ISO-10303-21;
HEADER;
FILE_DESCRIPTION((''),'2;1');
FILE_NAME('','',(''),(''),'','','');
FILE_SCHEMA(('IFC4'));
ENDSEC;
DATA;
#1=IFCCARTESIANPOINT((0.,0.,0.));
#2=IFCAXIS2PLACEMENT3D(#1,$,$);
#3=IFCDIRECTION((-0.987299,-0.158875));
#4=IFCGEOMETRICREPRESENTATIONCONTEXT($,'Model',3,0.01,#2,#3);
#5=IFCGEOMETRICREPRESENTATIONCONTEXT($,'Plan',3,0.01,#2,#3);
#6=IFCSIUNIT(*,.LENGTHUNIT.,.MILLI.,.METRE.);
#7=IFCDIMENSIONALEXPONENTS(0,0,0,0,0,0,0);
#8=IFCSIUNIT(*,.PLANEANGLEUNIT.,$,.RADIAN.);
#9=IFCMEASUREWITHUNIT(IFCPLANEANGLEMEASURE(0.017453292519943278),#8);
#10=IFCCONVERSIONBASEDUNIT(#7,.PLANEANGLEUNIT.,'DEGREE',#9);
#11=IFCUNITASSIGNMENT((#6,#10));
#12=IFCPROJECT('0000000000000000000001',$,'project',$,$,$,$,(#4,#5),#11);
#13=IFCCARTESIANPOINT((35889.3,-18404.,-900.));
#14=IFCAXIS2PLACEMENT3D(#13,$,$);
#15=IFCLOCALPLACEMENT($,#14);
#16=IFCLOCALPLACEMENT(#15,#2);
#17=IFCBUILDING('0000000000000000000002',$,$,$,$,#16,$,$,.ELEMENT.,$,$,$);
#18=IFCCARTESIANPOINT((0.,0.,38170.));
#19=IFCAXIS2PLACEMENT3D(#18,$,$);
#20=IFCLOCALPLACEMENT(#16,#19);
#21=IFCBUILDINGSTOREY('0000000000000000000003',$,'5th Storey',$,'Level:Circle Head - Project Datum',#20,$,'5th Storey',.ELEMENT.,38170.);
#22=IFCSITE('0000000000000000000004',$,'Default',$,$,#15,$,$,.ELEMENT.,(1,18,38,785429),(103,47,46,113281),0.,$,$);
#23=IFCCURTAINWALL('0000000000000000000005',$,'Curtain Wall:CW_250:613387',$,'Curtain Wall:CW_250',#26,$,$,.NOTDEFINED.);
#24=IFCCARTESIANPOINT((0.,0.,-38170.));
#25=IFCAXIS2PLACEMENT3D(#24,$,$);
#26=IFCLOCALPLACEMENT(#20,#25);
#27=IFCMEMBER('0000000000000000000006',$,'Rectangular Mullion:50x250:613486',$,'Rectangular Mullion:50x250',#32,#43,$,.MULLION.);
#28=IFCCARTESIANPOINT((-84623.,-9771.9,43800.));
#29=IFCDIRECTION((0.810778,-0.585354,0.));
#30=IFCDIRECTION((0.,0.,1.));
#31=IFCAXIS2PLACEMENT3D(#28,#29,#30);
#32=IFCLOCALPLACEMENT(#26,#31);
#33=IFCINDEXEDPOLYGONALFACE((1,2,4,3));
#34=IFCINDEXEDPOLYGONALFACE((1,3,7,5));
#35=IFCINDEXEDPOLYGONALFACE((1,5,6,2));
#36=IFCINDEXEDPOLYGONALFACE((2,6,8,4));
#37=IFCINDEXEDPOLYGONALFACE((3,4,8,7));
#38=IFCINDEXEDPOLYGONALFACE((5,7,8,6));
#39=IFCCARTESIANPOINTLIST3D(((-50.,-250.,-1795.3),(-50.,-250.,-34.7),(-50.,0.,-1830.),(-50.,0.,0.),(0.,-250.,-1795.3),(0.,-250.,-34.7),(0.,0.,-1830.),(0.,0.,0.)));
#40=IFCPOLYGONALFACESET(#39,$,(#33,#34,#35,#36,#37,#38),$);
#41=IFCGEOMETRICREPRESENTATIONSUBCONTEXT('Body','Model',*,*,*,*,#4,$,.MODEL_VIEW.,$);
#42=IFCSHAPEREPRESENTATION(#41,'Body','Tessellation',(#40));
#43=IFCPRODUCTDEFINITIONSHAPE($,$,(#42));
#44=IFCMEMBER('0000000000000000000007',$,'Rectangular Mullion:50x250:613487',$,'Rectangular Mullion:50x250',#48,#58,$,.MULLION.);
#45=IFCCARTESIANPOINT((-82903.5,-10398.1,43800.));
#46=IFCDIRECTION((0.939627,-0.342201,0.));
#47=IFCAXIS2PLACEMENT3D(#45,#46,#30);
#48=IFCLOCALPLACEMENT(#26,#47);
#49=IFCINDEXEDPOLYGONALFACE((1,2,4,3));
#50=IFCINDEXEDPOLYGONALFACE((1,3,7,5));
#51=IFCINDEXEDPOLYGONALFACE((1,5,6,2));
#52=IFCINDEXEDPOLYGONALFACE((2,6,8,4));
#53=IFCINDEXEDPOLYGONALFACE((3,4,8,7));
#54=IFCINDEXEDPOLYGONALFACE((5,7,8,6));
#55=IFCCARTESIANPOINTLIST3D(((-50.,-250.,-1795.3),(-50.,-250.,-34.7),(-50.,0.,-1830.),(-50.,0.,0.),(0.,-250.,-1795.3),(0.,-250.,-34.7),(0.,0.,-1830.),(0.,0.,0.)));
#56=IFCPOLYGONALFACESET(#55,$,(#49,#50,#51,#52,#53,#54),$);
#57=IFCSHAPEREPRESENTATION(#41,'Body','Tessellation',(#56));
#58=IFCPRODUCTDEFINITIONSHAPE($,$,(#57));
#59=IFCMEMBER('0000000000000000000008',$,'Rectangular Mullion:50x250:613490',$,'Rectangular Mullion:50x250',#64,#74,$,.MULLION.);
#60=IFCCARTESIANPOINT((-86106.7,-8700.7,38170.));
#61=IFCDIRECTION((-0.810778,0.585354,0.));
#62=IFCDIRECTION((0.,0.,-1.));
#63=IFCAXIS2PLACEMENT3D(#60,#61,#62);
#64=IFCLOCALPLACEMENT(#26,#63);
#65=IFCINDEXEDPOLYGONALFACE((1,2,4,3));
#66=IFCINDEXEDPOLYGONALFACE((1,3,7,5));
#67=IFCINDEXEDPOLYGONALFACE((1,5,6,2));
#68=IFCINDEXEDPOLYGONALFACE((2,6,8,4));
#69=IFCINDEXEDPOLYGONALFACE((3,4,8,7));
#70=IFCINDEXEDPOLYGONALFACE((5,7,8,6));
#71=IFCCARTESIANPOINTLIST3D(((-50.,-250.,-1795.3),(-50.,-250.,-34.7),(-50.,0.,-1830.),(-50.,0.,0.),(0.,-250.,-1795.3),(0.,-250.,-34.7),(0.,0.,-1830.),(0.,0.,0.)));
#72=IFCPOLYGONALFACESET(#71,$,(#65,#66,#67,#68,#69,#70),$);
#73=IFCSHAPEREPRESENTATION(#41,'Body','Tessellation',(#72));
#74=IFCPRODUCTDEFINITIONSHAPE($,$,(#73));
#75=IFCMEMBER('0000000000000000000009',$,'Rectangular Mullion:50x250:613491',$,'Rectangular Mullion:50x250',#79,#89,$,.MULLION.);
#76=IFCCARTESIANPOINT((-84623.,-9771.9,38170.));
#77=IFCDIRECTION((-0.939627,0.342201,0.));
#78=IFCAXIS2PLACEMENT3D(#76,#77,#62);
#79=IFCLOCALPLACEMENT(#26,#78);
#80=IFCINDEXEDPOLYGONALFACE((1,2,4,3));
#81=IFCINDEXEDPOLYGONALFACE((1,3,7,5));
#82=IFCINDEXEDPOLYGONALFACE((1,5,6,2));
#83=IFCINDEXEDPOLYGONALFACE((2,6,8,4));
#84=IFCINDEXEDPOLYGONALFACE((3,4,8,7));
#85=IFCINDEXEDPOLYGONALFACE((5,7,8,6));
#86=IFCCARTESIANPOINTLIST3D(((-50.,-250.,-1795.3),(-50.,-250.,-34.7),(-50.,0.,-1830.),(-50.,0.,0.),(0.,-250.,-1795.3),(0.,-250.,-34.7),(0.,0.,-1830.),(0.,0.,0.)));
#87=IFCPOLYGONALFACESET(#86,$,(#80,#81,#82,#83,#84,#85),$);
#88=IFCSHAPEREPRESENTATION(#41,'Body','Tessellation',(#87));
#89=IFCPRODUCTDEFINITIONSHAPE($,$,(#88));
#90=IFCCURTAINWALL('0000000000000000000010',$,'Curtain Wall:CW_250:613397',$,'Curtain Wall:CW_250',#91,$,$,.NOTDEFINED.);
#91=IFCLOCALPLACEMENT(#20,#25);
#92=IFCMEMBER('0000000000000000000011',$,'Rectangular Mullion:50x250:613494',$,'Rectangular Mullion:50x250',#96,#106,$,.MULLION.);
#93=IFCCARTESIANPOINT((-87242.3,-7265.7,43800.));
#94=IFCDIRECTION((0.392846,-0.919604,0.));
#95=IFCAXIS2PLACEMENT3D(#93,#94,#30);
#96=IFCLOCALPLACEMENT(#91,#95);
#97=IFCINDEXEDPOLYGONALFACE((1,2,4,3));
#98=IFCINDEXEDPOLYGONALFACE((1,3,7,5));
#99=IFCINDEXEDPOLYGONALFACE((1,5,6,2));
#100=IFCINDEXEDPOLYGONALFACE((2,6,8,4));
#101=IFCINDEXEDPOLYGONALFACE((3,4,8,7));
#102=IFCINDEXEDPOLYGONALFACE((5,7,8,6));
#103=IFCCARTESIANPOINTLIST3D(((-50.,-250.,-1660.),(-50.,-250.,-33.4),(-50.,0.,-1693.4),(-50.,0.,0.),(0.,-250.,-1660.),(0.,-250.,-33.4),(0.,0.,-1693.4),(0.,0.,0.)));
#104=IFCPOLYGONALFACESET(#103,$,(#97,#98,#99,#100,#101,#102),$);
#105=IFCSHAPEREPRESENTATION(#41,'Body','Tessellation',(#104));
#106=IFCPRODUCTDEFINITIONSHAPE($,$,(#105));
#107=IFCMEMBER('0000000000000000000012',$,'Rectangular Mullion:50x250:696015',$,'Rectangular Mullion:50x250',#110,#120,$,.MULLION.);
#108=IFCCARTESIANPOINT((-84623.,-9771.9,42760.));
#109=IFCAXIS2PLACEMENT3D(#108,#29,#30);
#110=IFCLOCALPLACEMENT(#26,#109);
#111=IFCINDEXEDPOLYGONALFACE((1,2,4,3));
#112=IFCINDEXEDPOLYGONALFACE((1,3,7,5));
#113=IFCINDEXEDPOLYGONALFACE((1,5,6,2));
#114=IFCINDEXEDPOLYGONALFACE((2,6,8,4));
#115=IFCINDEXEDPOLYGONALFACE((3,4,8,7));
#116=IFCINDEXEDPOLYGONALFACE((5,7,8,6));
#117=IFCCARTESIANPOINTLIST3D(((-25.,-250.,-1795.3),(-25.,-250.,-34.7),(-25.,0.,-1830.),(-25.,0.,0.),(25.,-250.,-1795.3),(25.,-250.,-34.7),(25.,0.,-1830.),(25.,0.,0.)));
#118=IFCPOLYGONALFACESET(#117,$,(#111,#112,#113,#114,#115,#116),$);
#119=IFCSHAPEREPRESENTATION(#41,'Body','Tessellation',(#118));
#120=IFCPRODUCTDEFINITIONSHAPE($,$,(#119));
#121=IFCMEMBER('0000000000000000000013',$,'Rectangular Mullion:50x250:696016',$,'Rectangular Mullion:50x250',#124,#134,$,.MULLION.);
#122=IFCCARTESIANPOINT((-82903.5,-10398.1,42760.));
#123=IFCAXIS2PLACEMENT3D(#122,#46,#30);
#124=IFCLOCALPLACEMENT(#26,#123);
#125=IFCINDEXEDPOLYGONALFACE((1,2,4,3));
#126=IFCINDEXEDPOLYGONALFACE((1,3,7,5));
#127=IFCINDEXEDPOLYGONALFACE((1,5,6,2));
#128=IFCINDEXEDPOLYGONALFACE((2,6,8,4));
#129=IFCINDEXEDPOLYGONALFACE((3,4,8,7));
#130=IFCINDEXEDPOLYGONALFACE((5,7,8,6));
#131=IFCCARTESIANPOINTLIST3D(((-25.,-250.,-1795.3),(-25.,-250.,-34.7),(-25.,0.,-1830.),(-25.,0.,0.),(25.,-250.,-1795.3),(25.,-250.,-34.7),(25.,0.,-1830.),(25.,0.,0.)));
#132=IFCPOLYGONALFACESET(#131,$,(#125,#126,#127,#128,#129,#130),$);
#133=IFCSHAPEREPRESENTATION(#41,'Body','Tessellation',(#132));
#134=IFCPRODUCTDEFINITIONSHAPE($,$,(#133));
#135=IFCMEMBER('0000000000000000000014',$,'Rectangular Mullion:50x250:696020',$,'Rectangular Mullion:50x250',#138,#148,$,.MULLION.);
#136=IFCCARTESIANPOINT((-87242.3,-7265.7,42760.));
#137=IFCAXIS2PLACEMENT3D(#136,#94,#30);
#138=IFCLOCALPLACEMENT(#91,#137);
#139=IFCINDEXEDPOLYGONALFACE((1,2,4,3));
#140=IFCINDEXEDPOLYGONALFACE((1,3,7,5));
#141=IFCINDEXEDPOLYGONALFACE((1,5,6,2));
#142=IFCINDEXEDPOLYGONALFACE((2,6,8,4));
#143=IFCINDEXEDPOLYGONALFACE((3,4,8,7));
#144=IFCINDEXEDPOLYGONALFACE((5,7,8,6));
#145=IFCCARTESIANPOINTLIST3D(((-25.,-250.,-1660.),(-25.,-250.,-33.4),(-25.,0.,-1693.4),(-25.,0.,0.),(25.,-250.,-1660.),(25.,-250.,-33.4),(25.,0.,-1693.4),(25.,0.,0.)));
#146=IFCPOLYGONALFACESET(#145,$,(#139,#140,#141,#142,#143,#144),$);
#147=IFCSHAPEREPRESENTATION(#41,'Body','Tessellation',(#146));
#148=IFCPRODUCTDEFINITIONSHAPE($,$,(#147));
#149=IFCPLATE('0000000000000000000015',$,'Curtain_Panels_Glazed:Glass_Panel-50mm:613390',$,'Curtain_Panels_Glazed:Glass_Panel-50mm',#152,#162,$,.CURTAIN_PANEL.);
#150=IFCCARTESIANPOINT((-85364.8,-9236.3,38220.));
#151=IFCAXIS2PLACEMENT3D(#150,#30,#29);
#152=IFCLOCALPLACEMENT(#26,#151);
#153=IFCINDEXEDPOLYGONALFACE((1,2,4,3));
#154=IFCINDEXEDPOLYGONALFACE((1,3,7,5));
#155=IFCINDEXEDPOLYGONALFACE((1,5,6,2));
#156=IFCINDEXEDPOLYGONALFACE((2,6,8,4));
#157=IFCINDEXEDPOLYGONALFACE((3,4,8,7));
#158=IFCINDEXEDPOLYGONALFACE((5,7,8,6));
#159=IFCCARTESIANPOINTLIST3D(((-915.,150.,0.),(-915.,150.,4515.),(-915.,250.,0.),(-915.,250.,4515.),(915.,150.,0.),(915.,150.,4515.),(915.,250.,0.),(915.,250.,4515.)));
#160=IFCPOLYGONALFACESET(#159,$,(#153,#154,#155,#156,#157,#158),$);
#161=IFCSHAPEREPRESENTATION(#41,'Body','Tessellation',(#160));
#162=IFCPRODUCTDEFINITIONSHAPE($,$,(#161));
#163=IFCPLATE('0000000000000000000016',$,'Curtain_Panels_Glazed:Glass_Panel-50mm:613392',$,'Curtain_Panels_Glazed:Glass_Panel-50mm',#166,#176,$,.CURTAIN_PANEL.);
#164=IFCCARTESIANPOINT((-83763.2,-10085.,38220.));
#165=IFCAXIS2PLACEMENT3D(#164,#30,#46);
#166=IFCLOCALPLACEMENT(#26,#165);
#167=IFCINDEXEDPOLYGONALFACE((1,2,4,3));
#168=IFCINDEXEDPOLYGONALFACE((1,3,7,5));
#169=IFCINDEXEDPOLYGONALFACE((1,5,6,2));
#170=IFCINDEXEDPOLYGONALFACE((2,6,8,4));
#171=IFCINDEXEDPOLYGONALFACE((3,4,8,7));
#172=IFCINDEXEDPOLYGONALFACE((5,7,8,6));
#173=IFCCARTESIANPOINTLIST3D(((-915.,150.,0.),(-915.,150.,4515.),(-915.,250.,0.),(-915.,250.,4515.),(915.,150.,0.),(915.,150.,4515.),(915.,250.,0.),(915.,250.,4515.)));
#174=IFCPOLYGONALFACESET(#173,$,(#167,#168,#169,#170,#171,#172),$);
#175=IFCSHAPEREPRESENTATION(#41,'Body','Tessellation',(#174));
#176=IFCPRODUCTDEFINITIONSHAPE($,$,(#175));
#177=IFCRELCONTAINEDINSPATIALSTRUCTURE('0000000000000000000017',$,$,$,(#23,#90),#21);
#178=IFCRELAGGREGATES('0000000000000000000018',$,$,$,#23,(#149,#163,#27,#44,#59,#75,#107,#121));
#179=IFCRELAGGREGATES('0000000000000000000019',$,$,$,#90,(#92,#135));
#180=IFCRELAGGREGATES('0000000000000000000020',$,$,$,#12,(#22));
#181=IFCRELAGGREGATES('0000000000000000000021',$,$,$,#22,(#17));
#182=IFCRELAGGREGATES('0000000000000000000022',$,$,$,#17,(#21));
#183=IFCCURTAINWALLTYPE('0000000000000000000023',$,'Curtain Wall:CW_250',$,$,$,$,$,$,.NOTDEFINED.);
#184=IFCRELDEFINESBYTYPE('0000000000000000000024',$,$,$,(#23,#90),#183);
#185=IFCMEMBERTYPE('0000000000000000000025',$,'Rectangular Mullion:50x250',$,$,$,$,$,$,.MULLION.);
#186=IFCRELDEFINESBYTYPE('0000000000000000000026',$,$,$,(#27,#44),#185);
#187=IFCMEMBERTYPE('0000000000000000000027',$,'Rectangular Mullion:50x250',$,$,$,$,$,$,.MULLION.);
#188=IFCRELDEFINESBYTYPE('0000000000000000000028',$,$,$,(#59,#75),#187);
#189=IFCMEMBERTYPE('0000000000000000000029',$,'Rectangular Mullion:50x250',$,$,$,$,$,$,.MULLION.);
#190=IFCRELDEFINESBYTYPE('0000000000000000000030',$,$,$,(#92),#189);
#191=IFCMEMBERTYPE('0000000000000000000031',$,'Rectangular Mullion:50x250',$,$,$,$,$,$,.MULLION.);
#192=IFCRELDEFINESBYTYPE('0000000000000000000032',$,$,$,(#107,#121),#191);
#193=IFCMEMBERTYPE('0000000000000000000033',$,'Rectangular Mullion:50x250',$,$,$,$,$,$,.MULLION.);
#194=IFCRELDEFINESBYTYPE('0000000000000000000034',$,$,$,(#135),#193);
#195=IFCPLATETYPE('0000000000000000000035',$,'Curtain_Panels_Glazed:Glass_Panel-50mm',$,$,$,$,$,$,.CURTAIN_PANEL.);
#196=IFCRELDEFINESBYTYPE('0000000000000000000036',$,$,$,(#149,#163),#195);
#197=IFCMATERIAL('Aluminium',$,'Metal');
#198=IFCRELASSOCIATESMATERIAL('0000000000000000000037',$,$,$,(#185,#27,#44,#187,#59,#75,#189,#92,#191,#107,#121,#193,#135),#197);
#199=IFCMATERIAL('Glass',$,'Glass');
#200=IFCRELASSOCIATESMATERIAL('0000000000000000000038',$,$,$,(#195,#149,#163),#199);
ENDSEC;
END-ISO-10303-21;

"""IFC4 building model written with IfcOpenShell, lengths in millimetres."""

from ifc_helpers import new_model, entity, si_unit, converted_unit, direction, frame, origin, place, context, subcontext, project, spatial, indexed_curve, outline, extrude, source, transform, mapped, material, type_object, type_shapes, element, aggregate, save


model = new_model("IFC4")

# Units and contexts
model_context = context("Model", 3, precision=0.01, world=origin(), true_north=direction((-0.987299, -0.158875)))
plan_context = context("Plan", 3, precision=0.01, world=origin(), true_north=direction((-0.987299, -0.158875)))
body_context = subcontext(model_context, "Body", "Model", "MODEL_VIEW")
ifc_project = project(units=[si_unit("LENGTHUNIT", "METRE", prefix="MILLI"), converted_unit("PLANEANGLEUNIT", "DEGREE", entity("IfcPlaneAngleMeasure", 0.017453292519943278), si_unit("PLANEANGLEUNIT", "RADIAN"), dimensions=[0, 0, 0, 0, 0, 0, 0])], contexts=[model_context, plan_context])

# Site, building, storey
site_placement = place(None, frame((35889.3, -18404.0, -900.0)))
site = spatial("IfcSite", under=ifc_project, at=site_placement, Name="Default", CompositionType="ELEMENT", RefLatitude=(1, 18, 38, 785429), RefLongitude=(103, 47, 46, 113281), RefElevation=0.0)
building_placement = place(site_placement, origin())
building = spatial("IfcBuilding", under=site, at=building_placement, CompositionType="ELEMENT")
storey_placement = place(building_placement, frame((0.0, 0.0, 38170.0)))
storey = spatial("IfcBuildingStorey", under=building, at=storey_placement, Name="5th Storey", ObjectType="Level:Circle Head - Project Datum", LongName="5th Storey", CompositionType="ELEMENT", Elevation=38170.0)

# Curtain walls, members
curtain_wall_type = type_object("IfcCurtainWallType", Name="Curtain Wall:CW_250", PredefinedType="NOTDEFINED")
curtain_wall_1_placement = place(storey_placement, frame((0.0, 0.0, -38170.0)))
curtain_wall_1 = element("IfcCurtainWall", 1, at=curtain_wall_1_placement, inside=storey, type_object=curtain_wall_type, Name="Curtain Wall:CW_250:613387", ObjectType="Curtain Wall:CW_250", PredefinedType="NOTDEFINED")
ifc_material_1 = material(Name="Aluminium", Category="Metal")
member_type_1 = type_object("IfcMemberType", Name="Rectangular Mullion:50x250", PredefinedType="MULLION", material=ifc_material_1)
shared_shape_1 = source(origin(), body_context, "Body", "SweptSolid", [
    extrude(outline(indexed_curve([(-880.3, -125.0), (880.3, -125.0), (915.0, 125.0), (-915.0, 125.0), (-880.3, -125.0)], self_intersect=False)), frame((-50.0, -125.0, -915.0), z_axis=(1.0, 0.0, 0.0), x_axis=(0.0, 0.0, -1.0)), (0.0, 0.0, 1.0), 50.0),
])
type_shapes(member_type_1, [shared_shape_1])
member_1_placement = place(curtain_wall_1_placement, frame((-84623.0, -9771.9, 43800.0), z_axis=(0.810778, -0.585354, 0.0), x_axis=(0.0, 0.0, 1.0)))
member_1 = element("IfcMember", 2, at=member_1_placement, type_object=member_type_1, material=ifc_material_1, Name="Rectangular Mullion:50x250:613486", ObjectType="Rectangular Mullion:50x250", PredefinedType="MULLION", context=body_context, shape_type="MappedRepresentation", body=[
    mapped(shared_shape_1, transform((0.0, 0.0, 0.0), scale=1.0)),
])
member_2_placement = place(curtain_wall_1_placement, frame((-82903.5, -10398.1, 43800.0), z_axis=(0.939627, -0.342201, 0.0), x_axis=(0.0, 0.0, 1.0)))
member_2 = element("IfcMember", 3, at=member_2_placement, type_object=member_type_1, material=ifc_material_1, Name="Rectangular Mullion:50x250:613487", ObjectType="Rectangular Mullion:50x250", PredefinedType="MULLION", context=body_context, shape_type="MappedRepresentation", body=[
    mapped(shared_shape_1, transform((0.0, 0.0, 0.0), scale=1.0)),
])
member_type_2 = type_object("IfcMemberType", Name="Rectangular Mullion:50x250", PredefinedType="MULLION", material=ifc_material_1)
shared_shape_2 = source(origin(), body_context, "Body", "SweptSolid", [
    extrude(outline(indexed_curve([(-880.3, -125.0), (880.3, -125.0), (915.0, 125.0), (-915.0, 125.0), (-880.3, -125.0)], self_intersect=False)), frame((-50.0, -125.0, -915.0), z_axis=(1.0, 0.0, 0.0), x_axis=(0.0, 0.0, -1.0)), (0.0, 0.0, 1.0), 50.0),
])
type_shapes(member_type_2, [shared_shape_2])
member_3_placement = place(curtain_wall_1_placement, frame((-86106.7, -8700.7, 38170.0), z_axis=(-0.810778, 0.585354, 0.0), x_axis=(0.0, 0.0, -1.0)))
member_3 = element("IfcMember", 4, at=member_3_placement, type_object=member_type_2, material=ifc_material_1, Name="Rectangular Mullion:50x250:613490", ObjectType="Rectangular Mullion:50x250", PredefinedType="MULLION", context=body_context, shape_type="MappedRepresentation", body=[
    mapped(shared_shape_2, transform((0.0, 0.0, 0.0), scale=1.0)),
])
member_4_placement = place(curtain_wall_1_placement, frame((-84623.0, -9771.9, 38170.0), z_axis=(-0.939627, 0.342201, 0.0), x_axis=(0.0, 0.0, -1.0)))
member_4 = element("IfcMember", 5, at=member_4_placement, type_object=member_type_2, material=ifc_material_1, Name="Rectangular Mullion:50x250:613491", ObjectType="Rectangular Mullion:50x250", PredefinedType="MULLION", context=body_context, shape_type="MappedRepresentation", body=[
    mapped(shared_shape_2, transform((0.0, 0.0, 0.0), scale=1.0)),
])
curtain_wall_2_placement = place(storey_placement, frame((0.0, 0.0, -38170.0)))
curtain_wall_2 = element("IfcCurtainWall", 6, at=curtain_wall_2_placement, inside=storey, type_object=curtain_wall_type, Name="Curtain Wall:CW_250:613397", ObjectType="Curtain Wall:CW_250", PredefinedType="NOTDEFINED")
member_type_3 = type_object("IfcMemberType", Name="Rectangular Mullion:50x250", PredefinedType="MULLION", material=ifc_material_1)
shared_shape_3 = source(origin(), body_context, "Body", "SweptSolid", [
    extrude(outline(indexed_curve([(-813.3, -125.0), (813.3, -125.0), (846.7, 125.0), (-846.7, 125.0), (-813.3, -125.0)], self_intersect=False)), frame((-50.0, -125.0, -846.7), z_axis=(1.0, 0.0, 0.0), x_axis=(0.0, 0.0, -1.0)), (0.0, 0.0, 1.0), 50.0),
])
type_shapes(member_type_3, [shared_shape_3])
member_5_placement = place(curtain_wall_2_placement, frame((-87242.3, -7265.7, 43800.0), z_axis=(0.392846, -0.919604, 0.0), x_axis=(0.0, 0.0, 1.0)))
member_5 = element("IfcMember", 7, at=member_5_placement, type_object=member_type_3, material=ifc_material_1, Name="Rectangular Mullion:50x250:613494", ObjectType="Rectangular Mullion:50x250", PredefinedType="MULLION", context=body_context, shape_type="MappedRepresentation", body=[
    mapped(shared_shape_3, transform((0.0, 0.0, 0.0), scale=1.0)),
])

# Members
member_type_4 = type_object("IfcMemberType", Name="Rectangular Mullion:50x250", PredefinedType="MULLION", material=ifc_material_1)
shared_shape_4 = source(origin(), body_context, "Body", "SweptSolid", [
    extrude(outline(indexed_curve([(-880.3, -125.0), (880.3, -125.0), (915.0, 125.0), (-915.0, 125.0), (-880.3, -125.0)], self_intersect=False)), frame((-25.0, -125.0, -915.0), z_axis=(1.0, 0.0, 0.0), x_axis=(0.0, 0.0, -1.0)), (0.0, 0.0, 1.0), 50.0),
])
type_shapes(member_type_4, [shared_shape_4])
member_6_placement = place(curtain_wall_1_placement, frame((-84623.0, -9771.9, 42760.0), z_axis=(0.810778, -0.585354, 0.0), x_axis=(0.0, 0.0, 1.0)))
member_6 = element("IfcMember", 8, at=member_6_placement, type_object=member_type_4, material=ifc_material_1, Name="Rectangular Mullion:50x250:696015", ObjectType="Rectangular Mullion:50x250", PredefinedType="MULLION", context=body_context, shape_type="MappedRepresentation", body=[
    mapped(shared_shape_4, transform((0.0, 0.0, 0.0), scale=1.0)),
])
member_7_placement = place(curtain_wall_1_placement, frame((-82903.5, -10398.1, 42760.0), z_axis=(0.939627, -0.342201, 0.0), x_axis=(0.0, 0.0, 1.0)))
member_7 = element("IfcMember", 9, at=member_7_placement, type_object=member_type_4, material=ifc_material_1, Name="Rectangular Mullion:50x250:696016", ObjectType="Rectangular Mullion:50x250", PredefinedType="MULLION", context=body_context, shape_type="MappedRepresentation", body=[
    mapped(shared_shape_4, transform((0.0, 0.0, 0.0), scale=1.0)),
])
member_type_5 = type_object("IfcMemberType", Name="Rectangular Mullion:50x250", PredefinedType="MULLION", material=ifc_material_1)
shared_shape_5 = source(origin(), body_context, "Body", "SweptSolid", [
    extrude(outline(indexed_curve([(-813.3, -125.0), (813.3, -125.0), (846.7, 125.0), (-846.7, 125.0), (-813.3, -125.0)], self_intersect=False)), frame((-25.0, -125.0, -846.7), z_axis=(1.0, 0.0, 0.0), x_axis=(0.0, 0.0, -1.0)), (0.0, 0.0, 1.0), 50.0),
])
type_shapes(member_type_5, [shared_shape_5])
member_8_placement = place(curtain_wall_2_placement, frame((-87242.3, -7265.7, 42760.0), z_axis=(0.392846, -0.919604, 0.0), x_axis=(0.0, 0.0, 1.0)))
member_8 = element("IfcMember", 10, at=member_8_placement, type_object=member_type_5, material=ifc_material_1, Name="Rectangular Mullion:50x250:696020", ObjectType="Rectangular Mullion:50x250", PredefinedType="MULLION", context=body_context, shape_type="MappedRepresentation", body=[
    mapped(shared_shape_5, transform((0.0, 0.0, 0.0), scale=1.0)),
])

# Plates
ifc_material_2 = material(Name="Glass", Category="Glass")
plate_type_1 = type_object("IfcPlateType", Name="Curtain_Panels_Glazed:Glass_Panel-50mm", PredefinedType="CURTAIN_PANEL", material=ifc_material_2)
shared_shape_6 = source(origin(), body_context, "Body", "SweptSolid", [
    extrude(outline(indexed_curve([(-50.0, -915.0), (50.0, -915.0), (50.0, 915.0), (-50.0, 915.0), (-50.0, -915.0)], self_intersect=False)), frame((0.0, 200.0, 0.0), z_axis=(0.0, 0.0, 1.0), x_axis=(0.0, 1.0, 0.0)), (0.0, 0.0, 1.0), 4515.0),
])
type_shapes(plate_type_1, [shared_shape_6])
plate_1_placement = place(curtain_wall_1_placement, frame((-85364.8, -9236.3, 38220.0), z_axis=(0.0, 0.0, 1.0), x_axis=(0.810778, -0.585354, 0.0)))
plate_1 = element("IfcPlate", 11, at=plate_1_placement, type_object=plate_type_1, material=ifc_material_2, Name="Curtain_Panels_Glazed:Glass_Panel-50mm:613390", ObjectType="Curtain_Panels_Glazed:Glass_Panel-50mm", PredefinedType="CURTAIN_PANEL", context=body_context, shape_type="MappedRepresentation", body=[
    mapped(shared_shape_6, transform((0.0, 0.0, 0.0), scale=1.0)),
])
plate_2_placement = place(curtain_wall_1_placement, frame((-83763.2, -10085.0, 38220.0), z_axis=(0.0, 0.0, 1.0), x_axis=(0.939627, -0.342201, 0.0)))
plate_2 = element("IfcPlate", 12, at=plate_2_placement, type_object=plate_type_1, material=ifc_material_2, Name="Curtain_Panels_Glazed:Glass_Panel-50mm:613392", ObjectType="Curtain_Panels_Glazed:Glass_Panel-50mm", PredefinedType="CURTAIN_PANEL", context=body_context, shape_type="MappedRepresentation", body=[
    mapped(shared_shape_6, transform((0.0, 0.0, 0.0), scale=1.0)),
])
aggregate(curtain_wall_1, [plate_1, plate_2, member_1, member_2, member_3, member_4, member_6, member_7])
aggregate(curtain_wall_2, [member_5, member_8])

save(model, "model.ifc")
